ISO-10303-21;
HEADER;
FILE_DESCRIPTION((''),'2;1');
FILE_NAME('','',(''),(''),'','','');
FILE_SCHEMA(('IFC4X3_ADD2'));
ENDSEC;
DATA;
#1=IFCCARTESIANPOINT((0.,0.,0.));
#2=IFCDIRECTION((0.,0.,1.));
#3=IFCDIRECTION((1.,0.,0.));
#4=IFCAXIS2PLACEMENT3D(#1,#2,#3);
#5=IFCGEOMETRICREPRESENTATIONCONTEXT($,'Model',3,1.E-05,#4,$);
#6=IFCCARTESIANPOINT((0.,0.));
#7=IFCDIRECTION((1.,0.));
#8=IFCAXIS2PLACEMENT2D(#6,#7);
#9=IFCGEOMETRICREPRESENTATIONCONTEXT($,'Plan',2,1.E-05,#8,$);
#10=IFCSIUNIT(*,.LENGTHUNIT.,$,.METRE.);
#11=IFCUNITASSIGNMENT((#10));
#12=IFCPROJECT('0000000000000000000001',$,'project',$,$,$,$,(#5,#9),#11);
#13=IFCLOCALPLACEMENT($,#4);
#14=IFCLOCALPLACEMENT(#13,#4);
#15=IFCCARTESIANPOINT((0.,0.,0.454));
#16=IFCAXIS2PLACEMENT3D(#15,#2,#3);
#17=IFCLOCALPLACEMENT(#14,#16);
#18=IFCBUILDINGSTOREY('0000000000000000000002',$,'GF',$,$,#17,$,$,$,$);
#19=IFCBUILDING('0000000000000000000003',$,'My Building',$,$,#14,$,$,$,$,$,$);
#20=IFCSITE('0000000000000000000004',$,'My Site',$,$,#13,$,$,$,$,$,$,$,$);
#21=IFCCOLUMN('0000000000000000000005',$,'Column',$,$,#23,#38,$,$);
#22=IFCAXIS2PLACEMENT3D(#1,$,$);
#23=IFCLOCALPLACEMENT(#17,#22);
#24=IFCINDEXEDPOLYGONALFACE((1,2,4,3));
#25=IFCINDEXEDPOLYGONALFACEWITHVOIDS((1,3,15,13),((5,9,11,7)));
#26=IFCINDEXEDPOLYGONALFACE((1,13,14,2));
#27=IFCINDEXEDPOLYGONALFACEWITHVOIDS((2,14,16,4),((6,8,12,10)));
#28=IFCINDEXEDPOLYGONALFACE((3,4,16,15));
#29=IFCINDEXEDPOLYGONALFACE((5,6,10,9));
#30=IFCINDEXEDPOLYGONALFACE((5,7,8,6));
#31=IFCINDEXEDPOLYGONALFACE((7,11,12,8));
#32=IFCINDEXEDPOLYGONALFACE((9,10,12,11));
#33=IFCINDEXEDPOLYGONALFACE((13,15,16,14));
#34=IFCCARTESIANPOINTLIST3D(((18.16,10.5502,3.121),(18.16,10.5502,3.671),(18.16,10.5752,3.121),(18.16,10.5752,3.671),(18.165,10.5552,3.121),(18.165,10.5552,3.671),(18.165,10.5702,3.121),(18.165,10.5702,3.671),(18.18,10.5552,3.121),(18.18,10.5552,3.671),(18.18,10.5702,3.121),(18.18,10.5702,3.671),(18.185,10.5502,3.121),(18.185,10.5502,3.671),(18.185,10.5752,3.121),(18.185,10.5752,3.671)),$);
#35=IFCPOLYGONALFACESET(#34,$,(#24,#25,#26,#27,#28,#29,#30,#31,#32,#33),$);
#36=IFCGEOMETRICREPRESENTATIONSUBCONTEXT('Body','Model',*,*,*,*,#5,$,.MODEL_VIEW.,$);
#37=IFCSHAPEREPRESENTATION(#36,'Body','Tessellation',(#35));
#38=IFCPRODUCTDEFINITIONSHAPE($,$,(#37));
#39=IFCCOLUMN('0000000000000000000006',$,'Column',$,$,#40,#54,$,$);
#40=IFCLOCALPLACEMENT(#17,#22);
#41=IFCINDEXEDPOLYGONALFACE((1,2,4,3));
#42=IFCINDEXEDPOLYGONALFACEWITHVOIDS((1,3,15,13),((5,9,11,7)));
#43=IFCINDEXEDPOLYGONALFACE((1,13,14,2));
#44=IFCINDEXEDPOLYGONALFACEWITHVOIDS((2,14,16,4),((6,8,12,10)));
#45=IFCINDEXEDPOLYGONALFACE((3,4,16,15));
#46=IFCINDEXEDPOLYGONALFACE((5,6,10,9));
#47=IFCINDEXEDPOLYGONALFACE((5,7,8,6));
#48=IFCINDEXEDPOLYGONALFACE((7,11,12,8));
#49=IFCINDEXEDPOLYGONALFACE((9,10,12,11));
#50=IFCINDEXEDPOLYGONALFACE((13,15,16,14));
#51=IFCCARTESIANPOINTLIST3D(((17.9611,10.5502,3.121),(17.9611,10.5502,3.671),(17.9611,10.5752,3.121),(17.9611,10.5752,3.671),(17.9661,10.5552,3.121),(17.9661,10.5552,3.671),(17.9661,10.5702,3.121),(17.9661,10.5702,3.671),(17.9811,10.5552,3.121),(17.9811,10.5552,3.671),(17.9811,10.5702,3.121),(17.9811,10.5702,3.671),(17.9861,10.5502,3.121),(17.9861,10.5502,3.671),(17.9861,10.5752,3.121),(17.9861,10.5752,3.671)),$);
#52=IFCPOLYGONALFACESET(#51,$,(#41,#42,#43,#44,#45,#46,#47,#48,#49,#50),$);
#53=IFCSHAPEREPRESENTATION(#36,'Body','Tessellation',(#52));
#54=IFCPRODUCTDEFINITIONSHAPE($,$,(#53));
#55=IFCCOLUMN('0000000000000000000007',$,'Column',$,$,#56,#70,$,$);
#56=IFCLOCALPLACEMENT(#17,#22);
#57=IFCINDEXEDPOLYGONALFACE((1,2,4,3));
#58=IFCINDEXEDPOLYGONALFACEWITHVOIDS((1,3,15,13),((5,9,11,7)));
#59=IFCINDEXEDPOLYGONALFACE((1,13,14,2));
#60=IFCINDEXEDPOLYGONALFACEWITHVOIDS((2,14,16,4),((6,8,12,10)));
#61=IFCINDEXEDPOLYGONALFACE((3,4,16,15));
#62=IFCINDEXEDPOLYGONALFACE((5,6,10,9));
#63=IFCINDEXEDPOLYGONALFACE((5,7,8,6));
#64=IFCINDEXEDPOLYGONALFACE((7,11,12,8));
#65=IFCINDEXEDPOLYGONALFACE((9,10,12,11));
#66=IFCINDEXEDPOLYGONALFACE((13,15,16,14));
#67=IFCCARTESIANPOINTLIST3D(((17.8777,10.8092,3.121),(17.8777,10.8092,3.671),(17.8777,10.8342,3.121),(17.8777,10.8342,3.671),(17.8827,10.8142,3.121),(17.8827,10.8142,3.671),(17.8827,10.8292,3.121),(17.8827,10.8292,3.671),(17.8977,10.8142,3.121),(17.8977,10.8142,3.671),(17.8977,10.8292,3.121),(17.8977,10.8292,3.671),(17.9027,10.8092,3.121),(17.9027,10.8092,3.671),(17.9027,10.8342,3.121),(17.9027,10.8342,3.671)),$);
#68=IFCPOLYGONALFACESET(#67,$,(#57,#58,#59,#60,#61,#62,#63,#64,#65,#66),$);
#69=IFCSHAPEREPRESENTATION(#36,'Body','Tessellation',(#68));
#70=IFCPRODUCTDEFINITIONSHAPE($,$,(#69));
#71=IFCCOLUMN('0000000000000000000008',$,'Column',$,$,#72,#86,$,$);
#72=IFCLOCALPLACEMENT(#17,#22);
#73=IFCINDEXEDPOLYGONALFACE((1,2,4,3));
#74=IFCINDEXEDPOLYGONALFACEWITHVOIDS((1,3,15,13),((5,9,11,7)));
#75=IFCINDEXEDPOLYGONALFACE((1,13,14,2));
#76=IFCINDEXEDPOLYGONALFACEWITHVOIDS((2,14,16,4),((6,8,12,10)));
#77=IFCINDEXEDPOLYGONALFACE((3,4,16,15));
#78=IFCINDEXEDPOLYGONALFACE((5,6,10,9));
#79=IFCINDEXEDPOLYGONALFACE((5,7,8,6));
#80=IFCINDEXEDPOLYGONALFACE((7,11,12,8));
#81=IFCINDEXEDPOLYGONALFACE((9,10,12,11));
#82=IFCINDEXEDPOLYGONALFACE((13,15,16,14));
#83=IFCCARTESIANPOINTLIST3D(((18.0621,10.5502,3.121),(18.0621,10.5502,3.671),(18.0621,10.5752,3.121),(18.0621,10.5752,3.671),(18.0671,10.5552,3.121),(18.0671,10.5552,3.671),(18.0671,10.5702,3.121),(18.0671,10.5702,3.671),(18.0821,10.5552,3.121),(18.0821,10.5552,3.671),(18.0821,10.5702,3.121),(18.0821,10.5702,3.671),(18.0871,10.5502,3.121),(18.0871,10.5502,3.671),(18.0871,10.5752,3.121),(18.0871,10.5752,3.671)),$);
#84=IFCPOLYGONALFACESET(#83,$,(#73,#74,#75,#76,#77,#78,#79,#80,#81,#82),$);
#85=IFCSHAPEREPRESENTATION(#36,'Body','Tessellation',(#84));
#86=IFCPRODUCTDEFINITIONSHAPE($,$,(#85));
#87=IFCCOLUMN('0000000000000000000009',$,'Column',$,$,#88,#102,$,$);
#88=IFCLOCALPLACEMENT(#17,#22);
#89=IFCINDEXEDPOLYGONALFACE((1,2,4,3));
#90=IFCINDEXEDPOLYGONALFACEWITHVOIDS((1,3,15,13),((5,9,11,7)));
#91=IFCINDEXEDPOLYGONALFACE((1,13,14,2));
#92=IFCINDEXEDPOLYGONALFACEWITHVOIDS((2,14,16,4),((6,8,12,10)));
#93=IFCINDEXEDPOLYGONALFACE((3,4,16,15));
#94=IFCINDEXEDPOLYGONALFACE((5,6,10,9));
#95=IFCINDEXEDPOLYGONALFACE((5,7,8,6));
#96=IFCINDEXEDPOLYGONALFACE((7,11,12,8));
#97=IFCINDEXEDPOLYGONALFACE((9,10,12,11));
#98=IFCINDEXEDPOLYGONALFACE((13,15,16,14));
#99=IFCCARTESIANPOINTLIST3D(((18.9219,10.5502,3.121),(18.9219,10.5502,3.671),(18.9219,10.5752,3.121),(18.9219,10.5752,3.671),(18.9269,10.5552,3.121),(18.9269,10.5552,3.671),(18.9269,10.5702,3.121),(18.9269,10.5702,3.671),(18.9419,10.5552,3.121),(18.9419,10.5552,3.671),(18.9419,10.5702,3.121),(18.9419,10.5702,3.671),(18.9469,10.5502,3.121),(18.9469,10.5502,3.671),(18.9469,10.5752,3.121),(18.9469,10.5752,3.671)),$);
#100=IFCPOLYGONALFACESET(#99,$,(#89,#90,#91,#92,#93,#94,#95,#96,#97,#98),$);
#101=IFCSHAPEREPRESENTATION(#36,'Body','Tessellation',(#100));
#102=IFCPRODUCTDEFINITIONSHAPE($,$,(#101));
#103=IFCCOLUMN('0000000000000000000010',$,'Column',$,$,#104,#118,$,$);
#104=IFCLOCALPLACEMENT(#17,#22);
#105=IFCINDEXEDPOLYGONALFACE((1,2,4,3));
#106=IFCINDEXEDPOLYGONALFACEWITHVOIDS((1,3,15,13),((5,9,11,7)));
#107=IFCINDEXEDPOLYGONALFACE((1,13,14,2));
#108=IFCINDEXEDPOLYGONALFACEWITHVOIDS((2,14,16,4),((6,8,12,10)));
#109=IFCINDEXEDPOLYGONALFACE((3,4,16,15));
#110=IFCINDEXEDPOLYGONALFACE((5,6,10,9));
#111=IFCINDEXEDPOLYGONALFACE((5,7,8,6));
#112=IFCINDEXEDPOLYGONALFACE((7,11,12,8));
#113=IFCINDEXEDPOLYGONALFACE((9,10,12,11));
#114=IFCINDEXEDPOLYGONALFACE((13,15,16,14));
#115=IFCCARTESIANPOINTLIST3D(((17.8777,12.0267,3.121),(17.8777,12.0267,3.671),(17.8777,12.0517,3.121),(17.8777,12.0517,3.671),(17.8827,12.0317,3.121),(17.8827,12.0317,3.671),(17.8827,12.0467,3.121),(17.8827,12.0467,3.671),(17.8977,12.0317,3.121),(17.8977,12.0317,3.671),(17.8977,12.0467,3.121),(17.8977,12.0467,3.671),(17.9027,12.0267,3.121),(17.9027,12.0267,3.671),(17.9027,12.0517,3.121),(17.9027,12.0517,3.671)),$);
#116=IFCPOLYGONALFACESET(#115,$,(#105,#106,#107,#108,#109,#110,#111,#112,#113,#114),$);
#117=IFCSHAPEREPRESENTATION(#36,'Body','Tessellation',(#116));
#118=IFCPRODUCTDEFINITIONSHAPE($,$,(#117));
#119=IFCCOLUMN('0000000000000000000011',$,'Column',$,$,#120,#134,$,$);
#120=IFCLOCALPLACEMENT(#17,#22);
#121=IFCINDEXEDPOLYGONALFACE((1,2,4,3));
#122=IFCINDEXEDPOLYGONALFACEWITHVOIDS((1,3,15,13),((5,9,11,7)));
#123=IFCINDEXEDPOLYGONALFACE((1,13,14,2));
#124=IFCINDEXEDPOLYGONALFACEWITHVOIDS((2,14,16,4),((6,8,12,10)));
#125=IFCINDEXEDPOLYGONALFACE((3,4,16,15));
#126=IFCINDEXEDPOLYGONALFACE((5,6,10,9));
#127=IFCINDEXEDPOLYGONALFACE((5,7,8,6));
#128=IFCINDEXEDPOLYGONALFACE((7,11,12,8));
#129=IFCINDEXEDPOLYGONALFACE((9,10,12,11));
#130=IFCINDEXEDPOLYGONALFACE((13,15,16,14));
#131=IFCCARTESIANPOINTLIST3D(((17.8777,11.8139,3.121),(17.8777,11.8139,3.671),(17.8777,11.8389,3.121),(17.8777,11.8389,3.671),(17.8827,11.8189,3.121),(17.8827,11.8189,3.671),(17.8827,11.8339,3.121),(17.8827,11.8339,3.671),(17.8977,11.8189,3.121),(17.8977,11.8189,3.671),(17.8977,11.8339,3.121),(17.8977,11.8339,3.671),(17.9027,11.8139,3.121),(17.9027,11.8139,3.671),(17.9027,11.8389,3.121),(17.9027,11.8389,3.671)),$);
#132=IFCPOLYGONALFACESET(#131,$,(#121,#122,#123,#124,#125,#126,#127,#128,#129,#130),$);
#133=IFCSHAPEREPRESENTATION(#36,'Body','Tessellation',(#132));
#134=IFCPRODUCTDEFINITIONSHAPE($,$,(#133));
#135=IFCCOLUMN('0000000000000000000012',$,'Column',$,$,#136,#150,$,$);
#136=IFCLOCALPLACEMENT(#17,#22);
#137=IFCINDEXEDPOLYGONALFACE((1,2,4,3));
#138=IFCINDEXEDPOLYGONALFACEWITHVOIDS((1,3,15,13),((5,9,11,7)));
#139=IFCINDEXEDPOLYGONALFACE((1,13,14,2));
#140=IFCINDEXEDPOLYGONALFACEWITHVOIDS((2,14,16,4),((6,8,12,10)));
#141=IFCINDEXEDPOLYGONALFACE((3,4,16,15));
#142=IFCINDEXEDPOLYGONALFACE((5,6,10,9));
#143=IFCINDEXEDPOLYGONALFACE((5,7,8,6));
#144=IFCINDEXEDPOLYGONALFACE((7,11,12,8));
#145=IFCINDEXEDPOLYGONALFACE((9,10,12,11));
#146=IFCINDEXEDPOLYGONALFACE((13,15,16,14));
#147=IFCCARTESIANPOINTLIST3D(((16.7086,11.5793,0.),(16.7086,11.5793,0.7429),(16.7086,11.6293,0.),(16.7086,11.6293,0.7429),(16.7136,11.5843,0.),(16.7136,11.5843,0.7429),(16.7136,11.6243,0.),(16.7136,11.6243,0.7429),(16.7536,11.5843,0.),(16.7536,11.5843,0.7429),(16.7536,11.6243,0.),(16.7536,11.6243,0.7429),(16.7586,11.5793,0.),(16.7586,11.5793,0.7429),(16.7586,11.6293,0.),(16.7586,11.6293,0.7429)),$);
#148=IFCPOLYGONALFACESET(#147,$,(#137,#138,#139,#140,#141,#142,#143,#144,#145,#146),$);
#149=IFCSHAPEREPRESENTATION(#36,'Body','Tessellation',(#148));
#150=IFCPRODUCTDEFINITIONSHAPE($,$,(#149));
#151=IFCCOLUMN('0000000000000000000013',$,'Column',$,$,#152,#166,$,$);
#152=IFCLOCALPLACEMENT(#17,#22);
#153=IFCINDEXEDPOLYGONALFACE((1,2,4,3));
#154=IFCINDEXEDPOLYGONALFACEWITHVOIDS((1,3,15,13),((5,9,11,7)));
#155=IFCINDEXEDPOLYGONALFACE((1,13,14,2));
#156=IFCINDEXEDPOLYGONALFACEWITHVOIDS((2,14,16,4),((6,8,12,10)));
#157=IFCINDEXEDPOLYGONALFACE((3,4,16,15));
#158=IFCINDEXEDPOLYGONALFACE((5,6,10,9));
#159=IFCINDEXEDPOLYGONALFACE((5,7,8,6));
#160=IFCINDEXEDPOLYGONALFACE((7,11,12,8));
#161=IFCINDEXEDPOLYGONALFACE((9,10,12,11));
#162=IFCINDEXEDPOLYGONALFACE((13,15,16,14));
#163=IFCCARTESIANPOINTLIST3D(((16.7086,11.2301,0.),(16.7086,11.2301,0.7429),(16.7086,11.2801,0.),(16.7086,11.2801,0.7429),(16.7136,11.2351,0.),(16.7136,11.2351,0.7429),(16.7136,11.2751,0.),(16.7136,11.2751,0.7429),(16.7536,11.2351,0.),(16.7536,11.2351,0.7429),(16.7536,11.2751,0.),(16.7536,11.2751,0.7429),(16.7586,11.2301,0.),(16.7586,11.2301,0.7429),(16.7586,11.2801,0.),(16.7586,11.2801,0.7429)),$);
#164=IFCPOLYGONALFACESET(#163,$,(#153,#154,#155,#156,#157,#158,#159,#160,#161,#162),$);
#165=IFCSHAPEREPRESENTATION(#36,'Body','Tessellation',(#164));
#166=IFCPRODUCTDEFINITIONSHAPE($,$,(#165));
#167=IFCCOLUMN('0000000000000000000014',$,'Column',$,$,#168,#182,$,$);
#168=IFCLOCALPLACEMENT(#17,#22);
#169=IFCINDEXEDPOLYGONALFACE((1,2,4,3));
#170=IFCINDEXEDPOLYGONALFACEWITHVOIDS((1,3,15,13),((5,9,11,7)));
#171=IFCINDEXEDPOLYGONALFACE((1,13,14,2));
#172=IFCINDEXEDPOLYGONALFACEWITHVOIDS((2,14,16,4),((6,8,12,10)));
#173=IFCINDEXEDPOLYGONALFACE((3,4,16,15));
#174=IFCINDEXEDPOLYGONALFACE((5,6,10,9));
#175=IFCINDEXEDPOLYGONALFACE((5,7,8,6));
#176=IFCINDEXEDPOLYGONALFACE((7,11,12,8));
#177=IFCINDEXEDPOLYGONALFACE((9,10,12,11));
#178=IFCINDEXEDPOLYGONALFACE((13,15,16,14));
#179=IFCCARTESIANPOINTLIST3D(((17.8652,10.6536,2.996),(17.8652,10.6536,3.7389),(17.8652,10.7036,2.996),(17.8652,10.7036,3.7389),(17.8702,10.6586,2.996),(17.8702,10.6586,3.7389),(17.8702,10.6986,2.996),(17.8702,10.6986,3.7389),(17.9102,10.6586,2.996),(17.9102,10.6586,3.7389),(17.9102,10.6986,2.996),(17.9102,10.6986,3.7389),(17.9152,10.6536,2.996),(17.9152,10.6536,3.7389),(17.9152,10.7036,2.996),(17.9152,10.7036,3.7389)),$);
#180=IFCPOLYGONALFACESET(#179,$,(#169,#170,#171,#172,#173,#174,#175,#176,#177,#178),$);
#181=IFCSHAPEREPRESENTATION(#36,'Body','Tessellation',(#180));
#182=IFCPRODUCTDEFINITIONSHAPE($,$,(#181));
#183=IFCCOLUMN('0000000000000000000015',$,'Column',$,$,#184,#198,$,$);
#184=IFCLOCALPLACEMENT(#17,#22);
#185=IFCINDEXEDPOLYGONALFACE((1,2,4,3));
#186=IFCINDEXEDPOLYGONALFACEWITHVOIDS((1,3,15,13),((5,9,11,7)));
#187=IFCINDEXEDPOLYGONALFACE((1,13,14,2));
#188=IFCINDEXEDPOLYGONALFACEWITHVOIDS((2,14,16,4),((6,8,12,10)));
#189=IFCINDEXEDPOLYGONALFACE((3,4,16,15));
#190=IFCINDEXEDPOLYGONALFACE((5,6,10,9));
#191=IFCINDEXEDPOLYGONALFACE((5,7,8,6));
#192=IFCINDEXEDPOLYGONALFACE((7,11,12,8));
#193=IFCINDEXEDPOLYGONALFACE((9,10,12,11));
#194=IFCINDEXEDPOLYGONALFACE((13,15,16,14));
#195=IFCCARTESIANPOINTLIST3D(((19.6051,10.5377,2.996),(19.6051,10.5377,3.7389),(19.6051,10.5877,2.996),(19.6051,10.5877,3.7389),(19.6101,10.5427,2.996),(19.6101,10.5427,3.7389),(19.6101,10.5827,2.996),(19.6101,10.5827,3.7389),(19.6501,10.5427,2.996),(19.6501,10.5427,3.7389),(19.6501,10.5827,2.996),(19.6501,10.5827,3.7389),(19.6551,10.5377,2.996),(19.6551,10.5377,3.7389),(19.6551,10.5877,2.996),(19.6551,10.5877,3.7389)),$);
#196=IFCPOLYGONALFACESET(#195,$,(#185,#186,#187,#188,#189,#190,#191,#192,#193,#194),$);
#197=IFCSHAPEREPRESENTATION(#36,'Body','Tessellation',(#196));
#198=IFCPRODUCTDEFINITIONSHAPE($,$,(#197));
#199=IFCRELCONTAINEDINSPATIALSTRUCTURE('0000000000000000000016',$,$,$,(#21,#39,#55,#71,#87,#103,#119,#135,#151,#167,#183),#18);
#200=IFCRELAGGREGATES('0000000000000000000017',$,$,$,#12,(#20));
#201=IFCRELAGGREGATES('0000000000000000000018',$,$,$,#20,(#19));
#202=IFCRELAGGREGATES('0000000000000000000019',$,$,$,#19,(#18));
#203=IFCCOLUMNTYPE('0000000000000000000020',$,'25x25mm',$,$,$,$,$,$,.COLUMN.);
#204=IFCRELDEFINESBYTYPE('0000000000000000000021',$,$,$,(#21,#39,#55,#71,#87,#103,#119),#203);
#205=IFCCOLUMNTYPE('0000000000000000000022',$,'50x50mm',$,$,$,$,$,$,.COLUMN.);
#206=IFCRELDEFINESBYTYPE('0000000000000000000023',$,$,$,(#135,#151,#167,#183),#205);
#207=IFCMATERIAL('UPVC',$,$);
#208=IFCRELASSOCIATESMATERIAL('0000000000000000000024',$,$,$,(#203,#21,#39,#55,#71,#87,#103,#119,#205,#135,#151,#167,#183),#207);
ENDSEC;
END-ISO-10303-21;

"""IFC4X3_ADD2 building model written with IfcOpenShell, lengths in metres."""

from ifc_helpers import new_model, si_unit, frame, origin_with_axes, origin_2d_with_axis, place, context, subcontext, project, spatial, hollow_rectangle, extrude, material, material_profile, profile_set, profile_usage, type_object, element, save


model = new_model("IFC4X3_ADD2")

# Units and contexts
model_context = context("Model", 3, precision=1e-05, world=origin_with_axes())
plan_context = context("Plan", 2, precision=1e-05, world=origin_2d_with_axis())
body_context = subcontext(model_context, "Body", "Model", "MODEL_VIEW")
ifc_project = project(units=[si_unit("LENGTHUNIT", "METRE")], contexts=[model_context, plan_context])

# Site, building, storey
site_placement = place(None, origin_with_axes())
site = spatial("IfcSite", under=ifc_project, at=site_placement, Name="My Site")
building_placement = place(site_placement, origin_with_axes())
building = spatial("IfcBuilding", under=site, at=building_placement, Name="My Building")
storey_placement = place(building_placement, frame((0.0, 0.0, 0.454), z_axis=(0.0, 0.0, 1.0), x_axis=(1.0, 0.0, 0.0)))
storey = spatial("IfcBuildingStorey", under=building, at=storey_placement, Name="GF")

# Columns
ifc_material_1 = material(Name="UPVC")
ifc_material_profile_1 = material_profile(ifc_material_1, hollow_rectangle(XDim=0.025, YDim=0.025, WallThickness=0.005))
ifc_profile_set_1 = profile_set([ifc_material_profile_1])
column_type_1 = type_object("IfcColumnType", Name="25x25mm", PredefinedType="COLUMN", material=ifc_profile_set_1)
ifc_profile_usage_1 = profile_usage(ifc_profile_set_1)
column_1_placement = place(storey_placement, frame((18.1725, 10.5627, 3.121), z_axis=(0.0, 0.0, 1.0), x_axis=(0.0, -1.0, 0.0)))
element("IfcColumn", 1, at=column_1_placement, inside=storey, type_object=column_type_1, material=ifc_profile_usage_1, Name="Column", context=body_context, shape_type="SweptSolid", body=[
    extrude(hollow_rectangle(XDim=0.025, YDim=0.025, WallThickness=0.005), origin_with_axes(), (0.0, 0.0, 1.0), 0.55),
])
ifc_profile_usage_2 = profile_usage(ifc_profile_set_1)
column_2_placement = place(storey_placement, frame((17.9736, 10.5627, 3.121), z_axis=(0.0, 0.0, 1.0), x_axis=(0.0, -1.0, 0.0)))
element("IfcColumn", 2, at=column_2_placement, inside=storey, type_object=column_type_1, material=ifc_profile_usage_2, Name="Column", context=body_context, shape_type="SweptSolid", body=[
    extrude(hollow_rectangle(XDim=0.025, YDim=0.025, WallThickness=0.005), origin_with_axes(), (0.0, 0.0, 1.0), 0.55),
])
ifc_profile_usage_3 = profile_usage(ifc_profile_set_1)
column_3_placement = place(storey_placement, frame((17.8902, 10.8217, 3.121), z_axis=(0.0, 0.0, 1.0), x_axis=(0.0, -1.0, 0.0)))
element("IfcColumn", 3, at=column_3_placement, inside=storey, type_object=column_type_1, material=ifc_profile_usage_3, Name="Column", context=body_context, shape_type="SweptSolid", body=[
    extrude(hollow_rectangle(XDim=0.025, YDim=0.025, WallThickness=0.005), origin_with_axes(), (0.0, 0.0, 1.0), 0.55),
])
ifc_profile_usage_4 = profile_usage(ifc_profile_set_1)
column_4_placement = place(storey_placement, frame((18.0746, 10.5627, 3.121), z_axis=(0.0, 0.0, 1.0), x_axis=(0.0, -1.0, 0.0)))
element("IfcColumn", 4, at=column_4_placement, inside=storey, type_object=column_type_1, material=ifc_profile_usage_4, Name="Column", context=body_context, shape_type="SweptSolid", body=[
    extrude(hollow_rectangle(XDim=0.025, YDim=0.025, WallThickness=0.005), origin_with_axes(), (0.0, 0.0, 1.0), 0.55),
])
ifc_profile_usage_5 = profile_usage(ifc_profile_set_1)
column_5_placement = place(storey_placement, frame((18.9344, 10.5627, 3.121), z_axis=(0.0, 0.0, 1.0), x_axis=(0.0, -1.0, 0.0)))
element("IfcColumn", 5, at=column_5_placement, inside=storey, type_object=column_type_1, material=ifc_profile_usage_5, Name="Column", context=body_context, shape_type="SweptSolid", body=[
    extrude(hollow_rectangle(XDim=0.025, YDim=0.025, WallThickness=0.005), origin_with_axes(), (0.0, 0.0, 1.0), 0.55),
])
ifc_profile_usage_6 = profile_usage(ifc_profile_set_1)
column_6_placement = place(storey_placement, frame((17.8902, 12.0392, 3.121), z_axis=(0.0, 0.0, 1.0), x_axis=(0.0, -1.0, 0.0)))
element("IfcColumn", 6, at=column_6_placement, inside=storey, type_object=column_type_1, material=ifc_profile_usage_6, Name="Column", context=body_context, shape_type="SweptSolid", body=[
    extrude(hollow_rectangle(XDim=0.025, YDim=0.025, WallThickness=0.005), origin_with_axes(), (0.0, 0.0, 1.0), 0.55),
])
ifc_profile_usage_7 = profile_usage(ifc_profile_set_1)
column_7_placement = place(storey_placement, frame((17.8902, 11.8264, 3.121), z_axis=(0.0, 0.0, 1.0), x_axis=(0.0, -1.0, 0.0)))
element("IfcColumn", 7, at=column_7_placement, inside=storey, type_object=column_type_1, material=ifc_profile_usage_7, Name="Column", context=body_context, shape_type="SweptSolid", body=[
    extrude(hollow_rectangle(XDim=0.025, YDim=0.025, WallThickness=0.005), origin_with_axes(), (0.0, 0.0, 1.0), 0.55),
])
ifc_material_profile_2 = material_profile(ifc_material_1, hollow_rectangle(XDim=0.05, YDim=0.05, WallThickness=0.005))
ifc_profile_set_2 = profile_set([ifc_material_profile_2])
ifc_profile_usage_8 = profile_usage(ifc_profile_set_2)
column_type_2 = type_object("IfcColumnType", Name="50x50mm", PredefinedType="COLUMN", material=ifc_profile_set_2)
column_8_placement = place(storey_placement, frame((16.7336, 11.6043, 0.0), z_axis=(0.0, 0.0, 1.0), x_axis=(0.0, -1.0, 0.0)))
element("IfcColumn", 8, at=column_8_placement, inside=storey, type_object=column_type_2, material=ifc_profile_usage_8, Name="Column", context=body_context, shape_type="SweptSolid", body=[
    extrude(hollow_rectangle(XDim=0.05, YDim=0.05, WallThickness=0.005), origin_with_axes(), (0.0, 0.0, 1.0), 0.7429),
])
ifc_profile_usage_9 = profile_usage(ifc_profile_set_2)
column_9_placement = place(storey_placement, frame((16.7336, 11.2551, 0.0), z_axis=(0.0, 0.0, 1.0), x_axis=(0.0, -1.0, 0.0)))
element("IfcColumn", 9, at=column_9_placement, inside=storey, type_object=column_type_2, material=ifc_profile_usage_9, Name="Column", context=body_context, shape_type="SweptSolid", body=[
    extrude(hollow_rectangle(XDim=0.05, YDim=0.05, WallThickness=0.005), origin_with_axes(), (0.0, 0.0, 1.0), 0.7429),
])
ifc_profile_usage_10 = profile_usage(ifc_profile_set_2)
column_10_placement = place(storey_placement, frame((17.8902, 10.6786, 2.996), z_axis=(0.0, 0.0, 1.0), x_axis=(0.0, -1.0, 0.0)))
element("IfcColumn", 10, at=column_10_placement, inside=storey, type_object=column_type_2, material=ifc_profile_usage_10, Name="Column", context=body_context, shape_type="SweptSolid", body=[
    extrude(hollow_rectangle(XDim=0.05, YDim=0.05, WallThickness=0.005), origin_with_axes(), (0.0, 0.0, 1.0), 0.7429),
])
ifc_profile_usage_11 = profile_usage(ifc_profile_set_2)
column_11_placement = place(storey_placement, frame((19.6301, 10.5627, 2.996), z_axis=(0.0, 0.0, 1.0), x_axis=(1.0, 0.0, 0.0)))
element("IfcColumn", 11, at=column_11_placement, inside=storey, type_object=column_type_2, material=ifc_profile_usage_11, Name="Column", context=body_context, shape_type="SweptSolid", body=[
    extrude(hollow_rectangle(XDim=0.05, YDim=0.05, WallThickness=0.005), origin_with_axes(), (0.0, 0.0, 1.0), 0.7429),
])

save(model, "model.ifc")
